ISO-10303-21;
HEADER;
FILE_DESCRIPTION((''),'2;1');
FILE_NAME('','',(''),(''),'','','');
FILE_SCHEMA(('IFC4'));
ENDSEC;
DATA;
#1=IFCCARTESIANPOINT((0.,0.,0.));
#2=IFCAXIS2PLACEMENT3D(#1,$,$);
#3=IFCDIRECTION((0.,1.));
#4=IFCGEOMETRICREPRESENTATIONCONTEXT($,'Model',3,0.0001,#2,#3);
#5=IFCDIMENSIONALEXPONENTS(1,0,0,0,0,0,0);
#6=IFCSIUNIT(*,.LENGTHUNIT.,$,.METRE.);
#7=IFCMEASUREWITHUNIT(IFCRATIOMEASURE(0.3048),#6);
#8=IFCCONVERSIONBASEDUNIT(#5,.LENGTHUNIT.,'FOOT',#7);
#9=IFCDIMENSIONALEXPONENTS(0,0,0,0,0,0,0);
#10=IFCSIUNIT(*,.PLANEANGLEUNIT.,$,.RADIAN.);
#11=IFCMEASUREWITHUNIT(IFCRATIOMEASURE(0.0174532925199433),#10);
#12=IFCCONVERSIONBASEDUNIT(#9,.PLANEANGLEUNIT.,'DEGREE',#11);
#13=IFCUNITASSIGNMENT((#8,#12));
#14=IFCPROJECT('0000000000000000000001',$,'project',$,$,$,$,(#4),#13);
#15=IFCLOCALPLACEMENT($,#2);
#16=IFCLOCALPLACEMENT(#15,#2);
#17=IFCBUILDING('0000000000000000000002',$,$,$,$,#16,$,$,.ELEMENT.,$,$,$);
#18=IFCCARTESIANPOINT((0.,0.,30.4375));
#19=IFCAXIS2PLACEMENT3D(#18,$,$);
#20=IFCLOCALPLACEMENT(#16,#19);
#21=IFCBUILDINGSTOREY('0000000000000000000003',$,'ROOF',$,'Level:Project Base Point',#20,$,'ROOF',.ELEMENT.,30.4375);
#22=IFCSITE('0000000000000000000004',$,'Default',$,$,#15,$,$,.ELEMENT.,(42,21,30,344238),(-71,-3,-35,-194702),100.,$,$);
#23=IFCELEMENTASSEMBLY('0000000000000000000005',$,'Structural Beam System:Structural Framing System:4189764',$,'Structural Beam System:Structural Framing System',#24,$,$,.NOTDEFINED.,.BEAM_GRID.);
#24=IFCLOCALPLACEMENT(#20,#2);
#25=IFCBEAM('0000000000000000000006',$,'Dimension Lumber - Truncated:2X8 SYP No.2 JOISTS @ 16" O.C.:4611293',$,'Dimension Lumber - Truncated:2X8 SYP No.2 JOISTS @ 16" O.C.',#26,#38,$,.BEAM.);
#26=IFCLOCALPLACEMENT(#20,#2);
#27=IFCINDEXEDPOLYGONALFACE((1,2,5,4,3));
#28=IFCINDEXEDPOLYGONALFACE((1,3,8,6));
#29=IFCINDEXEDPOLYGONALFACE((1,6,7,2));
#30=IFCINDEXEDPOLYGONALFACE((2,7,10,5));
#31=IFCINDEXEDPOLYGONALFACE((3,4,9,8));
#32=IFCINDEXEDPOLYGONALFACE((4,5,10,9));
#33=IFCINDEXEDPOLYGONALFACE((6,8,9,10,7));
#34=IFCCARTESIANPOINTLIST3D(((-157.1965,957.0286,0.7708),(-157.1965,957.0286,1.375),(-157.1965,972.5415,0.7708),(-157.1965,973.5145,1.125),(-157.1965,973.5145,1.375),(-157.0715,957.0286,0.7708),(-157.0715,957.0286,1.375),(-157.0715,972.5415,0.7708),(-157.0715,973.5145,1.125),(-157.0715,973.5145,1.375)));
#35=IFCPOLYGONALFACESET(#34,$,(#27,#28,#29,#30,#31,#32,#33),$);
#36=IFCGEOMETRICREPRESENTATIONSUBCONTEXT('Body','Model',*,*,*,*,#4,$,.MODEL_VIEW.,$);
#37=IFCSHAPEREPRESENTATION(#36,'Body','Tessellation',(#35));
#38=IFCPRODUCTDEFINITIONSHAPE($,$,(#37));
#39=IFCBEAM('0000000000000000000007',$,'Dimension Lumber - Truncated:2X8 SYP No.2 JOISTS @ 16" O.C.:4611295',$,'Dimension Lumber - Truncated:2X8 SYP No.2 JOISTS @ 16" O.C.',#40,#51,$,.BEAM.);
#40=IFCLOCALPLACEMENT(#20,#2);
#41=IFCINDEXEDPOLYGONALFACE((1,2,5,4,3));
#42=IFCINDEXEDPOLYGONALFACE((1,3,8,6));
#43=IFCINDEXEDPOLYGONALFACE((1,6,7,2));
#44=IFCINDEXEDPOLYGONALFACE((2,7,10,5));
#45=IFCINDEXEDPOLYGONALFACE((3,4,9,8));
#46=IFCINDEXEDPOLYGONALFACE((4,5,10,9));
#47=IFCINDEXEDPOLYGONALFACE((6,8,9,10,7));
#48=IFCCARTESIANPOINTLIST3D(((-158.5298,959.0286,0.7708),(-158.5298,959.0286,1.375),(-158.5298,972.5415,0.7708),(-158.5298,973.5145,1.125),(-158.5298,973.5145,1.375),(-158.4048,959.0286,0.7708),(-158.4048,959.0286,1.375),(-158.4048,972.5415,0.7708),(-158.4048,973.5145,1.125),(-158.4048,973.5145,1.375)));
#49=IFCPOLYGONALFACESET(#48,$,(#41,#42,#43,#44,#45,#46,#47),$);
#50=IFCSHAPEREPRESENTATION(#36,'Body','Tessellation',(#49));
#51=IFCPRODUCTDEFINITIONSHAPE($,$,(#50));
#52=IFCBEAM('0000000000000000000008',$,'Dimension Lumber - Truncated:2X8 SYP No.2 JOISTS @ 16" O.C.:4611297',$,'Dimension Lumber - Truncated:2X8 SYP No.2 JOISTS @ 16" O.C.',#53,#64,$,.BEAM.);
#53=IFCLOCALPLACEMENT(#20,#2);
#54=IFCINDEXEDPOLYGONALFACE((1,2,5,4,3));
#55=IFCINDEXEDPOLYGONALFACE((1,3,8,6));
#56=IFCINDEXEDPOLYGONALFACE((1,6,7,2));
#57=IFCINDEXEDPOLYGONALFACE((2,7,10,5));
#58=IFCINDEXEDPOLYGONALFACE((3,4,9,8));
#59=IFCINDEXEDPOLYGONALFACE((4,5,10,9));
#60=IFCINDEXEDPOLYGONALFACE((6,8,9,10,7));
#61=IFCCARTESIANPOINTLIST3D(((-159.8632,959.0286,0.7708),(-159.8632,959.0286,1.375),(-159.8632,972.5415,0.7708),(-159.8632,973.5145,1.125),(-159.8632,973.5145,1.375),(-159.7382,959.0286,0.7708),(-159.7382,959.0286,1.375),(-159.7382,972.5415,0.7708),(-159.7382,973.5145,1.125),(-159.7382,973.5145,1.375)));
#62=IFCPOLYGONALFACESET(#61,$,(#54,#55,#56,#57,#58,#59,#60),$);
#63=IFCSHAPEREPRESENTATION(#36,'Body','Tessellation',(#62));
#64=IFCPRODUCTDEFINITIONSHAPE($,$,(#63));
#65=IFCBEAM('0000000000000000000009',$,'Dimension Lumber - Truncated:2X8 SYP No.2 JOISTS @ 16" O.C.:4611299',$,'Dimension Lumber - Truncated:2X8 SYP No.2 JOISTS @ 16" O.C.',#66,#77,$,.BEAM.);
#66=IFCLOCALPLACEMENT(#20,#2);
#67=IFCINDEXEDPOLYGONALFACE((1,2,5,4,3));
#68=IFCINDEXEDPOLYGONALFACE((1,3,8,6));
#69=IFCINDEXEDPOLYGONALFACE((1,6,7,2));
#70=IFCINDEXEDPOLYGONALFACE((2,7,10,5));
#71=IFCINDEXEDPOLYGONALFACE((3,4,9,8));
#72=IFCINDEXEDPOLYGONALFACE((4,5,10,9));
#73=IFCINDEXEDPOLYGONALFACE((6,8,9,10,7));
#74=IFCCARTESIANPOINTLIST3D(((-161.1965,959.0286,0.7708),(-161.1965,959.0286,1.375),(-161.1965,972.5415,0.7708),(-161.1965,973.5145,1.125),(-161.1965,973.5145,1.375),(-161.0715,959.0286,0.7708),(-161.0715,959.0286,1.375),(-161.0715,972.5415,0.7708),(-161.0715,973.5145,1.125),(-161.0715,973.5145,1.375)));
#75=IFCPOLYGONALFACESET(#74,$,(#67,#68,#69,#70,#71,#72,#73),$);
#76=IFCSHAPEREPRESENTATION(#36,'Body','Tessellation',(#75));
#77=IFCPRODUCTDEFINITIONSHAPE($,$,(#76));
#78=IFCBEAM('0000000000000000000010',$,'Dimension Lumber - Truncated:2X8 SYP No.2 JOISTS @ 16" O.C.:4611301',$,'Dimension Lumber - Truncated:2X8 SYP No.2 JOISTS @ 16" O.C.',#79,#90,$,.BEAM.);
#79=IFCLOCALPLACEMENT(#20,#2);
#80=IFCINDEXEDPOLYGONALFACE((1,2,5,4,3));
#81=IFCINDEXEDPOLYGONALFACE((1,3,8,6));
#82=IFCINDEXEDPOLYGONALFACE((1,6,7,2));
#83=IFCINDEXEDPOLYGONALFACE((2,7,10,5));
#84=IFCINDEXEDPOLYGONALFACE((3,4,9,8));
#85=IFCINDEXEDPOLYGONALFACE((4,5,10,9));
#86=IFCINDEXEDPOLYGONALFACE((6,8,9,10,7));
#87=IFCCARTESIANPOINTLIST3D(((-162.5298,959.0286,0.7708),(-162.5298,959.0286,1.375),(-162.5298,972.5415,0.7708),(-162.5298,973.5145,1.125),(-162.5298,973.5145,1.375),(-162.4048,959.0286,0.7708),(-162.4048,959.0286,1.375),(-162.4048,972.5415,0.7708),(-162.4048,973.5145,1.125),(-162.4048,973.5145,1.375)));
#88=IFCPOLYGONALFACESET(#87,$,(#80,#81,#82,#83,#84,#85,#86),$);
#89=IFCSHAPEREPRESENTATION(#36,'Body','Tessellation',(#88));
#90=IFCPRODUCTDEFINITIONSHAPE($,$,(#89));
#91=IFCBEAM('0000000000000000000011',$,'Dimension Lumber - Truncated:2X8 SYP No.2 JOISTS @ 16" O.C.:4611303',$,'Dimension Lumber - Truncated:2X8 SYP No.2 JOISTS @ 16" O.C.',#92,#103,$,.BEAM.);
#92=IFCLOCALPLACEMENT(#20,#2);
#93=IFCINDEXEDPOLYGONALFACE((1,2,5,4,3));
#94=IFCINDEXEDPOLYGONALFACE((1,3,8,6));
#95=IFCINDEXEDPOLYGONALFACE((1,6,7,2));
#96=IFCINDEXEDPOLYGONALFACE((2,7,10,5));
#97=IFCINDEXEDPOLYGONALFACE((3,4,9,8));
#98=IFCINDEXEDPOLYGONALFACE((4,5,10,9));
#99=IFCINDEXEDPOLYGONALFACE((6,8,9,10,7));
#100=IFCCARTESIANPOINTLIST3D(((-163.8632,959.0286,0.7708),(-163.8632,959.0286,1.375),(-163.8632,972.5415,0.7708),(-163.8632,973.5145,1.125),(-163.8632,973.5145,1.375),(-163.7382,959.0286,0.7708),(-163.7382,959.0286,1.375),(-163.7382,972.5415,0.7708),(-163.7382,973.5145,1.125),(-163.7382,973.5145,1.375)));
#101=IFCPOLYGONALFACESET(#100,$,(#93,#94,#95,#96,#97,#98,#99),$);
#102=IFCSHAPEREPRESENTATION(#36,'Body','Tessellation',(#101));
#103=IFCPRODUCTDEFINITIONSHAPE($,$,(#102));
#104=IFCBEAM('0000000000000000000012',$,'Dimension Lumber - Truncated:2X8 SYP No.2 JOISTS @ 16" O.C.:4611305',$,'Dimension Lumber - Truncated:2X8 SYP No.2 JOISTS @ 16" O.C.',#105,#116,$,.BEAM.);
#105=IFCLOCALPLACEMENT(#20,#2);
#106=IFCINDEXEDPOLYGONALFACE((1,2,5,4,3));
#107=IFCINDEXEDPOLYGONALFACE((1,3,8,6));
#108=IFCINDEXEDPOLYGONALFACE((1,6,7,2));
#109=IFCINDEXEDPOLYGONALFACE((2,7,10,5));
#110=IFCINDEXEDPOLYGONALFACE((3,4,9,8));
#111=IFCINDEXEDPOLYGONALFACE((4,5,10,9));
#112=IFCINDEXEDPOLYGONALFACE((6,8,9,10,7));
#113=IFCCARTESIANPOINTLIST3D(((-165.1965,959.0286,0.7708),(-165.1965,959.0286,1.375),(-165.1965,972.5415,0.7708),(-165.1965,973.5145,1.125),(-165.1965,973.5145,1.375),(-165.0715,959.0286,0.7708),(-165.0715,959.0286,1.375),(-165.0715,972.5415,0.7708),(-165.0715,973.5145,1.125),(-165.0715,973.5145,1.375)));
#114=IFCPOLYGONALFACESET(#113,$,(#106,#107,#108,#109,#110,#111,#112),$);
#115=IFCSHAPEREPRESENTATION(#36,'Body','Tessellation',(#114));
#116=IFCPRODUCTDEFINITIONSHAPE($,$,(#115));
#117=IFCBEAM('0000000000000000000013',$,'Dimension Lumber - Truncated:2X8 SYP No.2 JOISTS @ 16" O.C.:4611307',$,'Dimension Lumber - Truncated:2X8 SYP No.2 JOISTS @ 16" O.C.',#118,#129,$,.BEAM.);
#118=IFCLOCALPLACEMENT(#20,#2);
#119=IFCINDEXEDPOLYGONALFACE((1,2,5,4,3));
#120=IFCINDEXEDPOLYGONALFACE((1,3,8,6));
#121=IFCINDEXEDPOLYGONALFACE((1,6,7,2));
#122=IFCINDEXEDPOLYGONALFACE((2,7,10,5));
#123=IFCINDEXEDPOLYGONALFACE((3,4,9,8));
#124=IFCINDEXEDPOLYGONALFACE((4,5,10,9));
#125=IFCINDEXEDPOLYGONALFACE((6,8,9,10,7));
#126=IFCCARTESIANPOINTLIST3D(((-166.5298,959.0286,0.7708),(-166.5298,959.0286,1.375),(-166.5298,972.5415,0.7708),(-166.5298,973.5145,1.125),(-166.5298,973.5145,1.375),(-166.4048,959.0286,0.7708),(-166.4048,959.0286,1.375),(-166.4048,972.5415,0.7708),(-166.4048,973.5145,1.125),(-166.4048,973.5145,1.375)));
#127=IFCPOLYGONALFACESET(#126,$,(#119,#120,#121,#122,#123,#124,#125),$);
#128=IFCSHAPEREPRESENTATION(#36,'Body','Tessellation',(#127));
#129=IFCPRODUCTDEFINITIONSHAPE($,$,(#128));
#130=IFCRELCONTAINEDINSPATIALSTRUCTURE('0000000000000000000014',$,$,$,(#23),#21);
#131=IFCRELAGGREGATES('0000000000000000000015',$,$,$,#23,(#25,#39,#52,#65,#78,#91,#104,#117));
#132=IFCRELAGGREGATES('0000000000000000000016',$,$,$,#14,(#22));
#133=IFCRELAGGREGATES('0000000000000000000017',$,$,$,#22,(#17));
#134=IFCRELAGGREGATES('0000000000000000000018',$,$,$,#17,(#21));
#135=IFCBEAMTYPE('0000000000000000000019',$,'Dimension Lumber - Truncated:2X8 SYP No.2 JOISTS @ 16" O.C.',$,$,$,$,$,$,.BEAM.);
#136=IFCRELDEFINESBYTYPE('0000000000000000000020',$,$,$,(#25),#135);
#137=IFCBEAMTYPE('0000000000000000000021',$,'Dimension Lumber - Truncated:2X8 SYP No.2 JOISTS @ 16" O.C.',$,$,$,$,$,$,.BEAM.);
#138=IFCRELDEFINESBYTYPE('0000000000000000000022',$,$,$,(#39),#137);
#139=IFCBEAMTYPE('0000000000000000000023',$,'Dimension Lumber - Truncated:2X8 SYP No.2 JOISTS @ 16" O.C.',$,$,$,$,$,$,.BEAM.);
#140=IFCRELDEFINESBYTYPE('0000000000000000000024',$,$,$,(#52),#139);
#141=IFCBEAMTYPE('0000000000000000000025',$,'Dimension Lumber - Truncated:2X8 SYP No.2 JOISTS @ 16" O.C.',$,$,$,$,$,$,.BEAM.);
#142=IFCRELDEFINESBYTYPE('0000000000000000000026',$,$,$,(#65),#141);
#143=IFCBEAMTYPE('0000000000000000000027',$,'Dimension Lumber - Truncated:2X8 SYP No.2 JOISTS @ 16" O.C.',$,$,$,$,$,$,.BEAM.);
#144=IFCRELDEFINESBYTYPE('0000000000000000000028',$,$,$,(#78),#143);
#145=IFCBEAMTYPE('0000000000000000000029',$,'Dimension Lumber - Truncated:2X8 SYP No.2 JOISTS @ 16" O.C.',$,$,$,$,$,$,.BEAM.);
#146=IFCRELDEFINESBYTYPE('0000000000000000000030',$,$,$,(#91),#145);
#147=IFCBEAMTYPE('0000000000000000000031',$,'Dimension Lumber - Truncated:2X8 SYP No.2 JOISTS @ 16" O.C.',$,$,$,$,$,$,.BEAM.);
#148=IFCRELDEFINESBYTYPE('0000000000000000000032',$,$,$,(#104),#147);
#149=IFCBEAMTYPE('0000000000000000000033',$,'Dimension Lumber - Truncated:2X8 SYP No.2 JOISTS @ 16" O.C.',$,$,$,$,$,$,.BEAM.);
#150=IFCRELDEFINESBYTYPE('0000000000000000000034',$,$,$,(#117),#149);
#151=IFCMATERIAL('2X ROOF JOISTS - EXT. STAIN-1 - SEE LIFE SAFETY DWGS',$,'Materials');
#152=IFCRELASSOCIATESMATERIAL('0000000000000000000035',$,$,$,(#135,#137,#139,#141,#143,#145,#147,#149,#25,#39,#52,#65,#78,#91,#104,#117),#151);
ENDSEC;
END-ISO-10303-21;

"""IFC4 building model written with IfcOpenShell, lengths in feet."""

from ifc_helpers import new_model, entity, si_unit, converted_unit, direction, frame, frame_2d, origin, place, context, subcontext, project, spatial, rectangle, extrude, clip, halfspace, source, transform, mapped, material, material_profile, profile_set, profile_usage, type_object, type_shapes, element, aggregate, save


model = new_model("IFC4")

# Units and contexts
model_context = context("Model", 3, precision=0.0001, world=origin(), true_north=direction((0.0, 1.0)))
body_context = subcontext(model_context, "Body", "Model", "MODEL_VIEW")
ifc_project = project(units=[converted_unit("LENGTHUNIT", "FOOT", entity("IfcRatioMeasure", 0.3048), si_unit("LENGTHUNIT", "METRE"), dimensions=[1, 0, 0, 0, 0, 0, 0]), converted_unit("PLANEANGLEUNIT", "DEGREE", entity("IfcRatioMeasure", 0.0174532925199433), si_unit("PLANEANGLEUNIT", "RADIAN"), dimensions=[0, 0, 0, 0, 0, 0, 0])], contexts=[model_context])

# Site, building, storey
site_placement = place(None, origin())
site = spatial("IfcSite", under=ifc_project, at=site_placement, Name="Default", CompositionType="ELEMENT", RefLatitude=(42, 21, 30, 344238), RefLongitude=(-71, -3, -35, -194702), RefElevation=100.0)
building_placement = place(site_placement, origin())
building = spatial("IfcBuilding", under=site, at=building_placement, CompositionType="ELEMENT")
storey_placement = place(building_placement, frame((0.0, 0.0, 30.4375)))
storey = spatial("IfcBuildingStorey", under=building, at=storey_placement, Name="ROOF", ObjectType="Level:Project Base Point", LongName="ROOF", CompositionType="ELEMENT", Elevation=30.4375)

# Element assembly, beams
assembly_1_placement = place(storey_placement, origin())
assembly_1 = element("IfcElementAssembly", 1, at=assembly_1_placement, inside=storey, Name="Structural Beam System:Structural Framing System:4189764", ObjectType="Structural Beam System:Structural Framing System", AssemblyPlace="NOTDEFINED", PredefinedType="BEAM_GRID")
ifc_material_1 = material(Name="2X ROOF JOISTS - EXT. STAIN-1 - SEE LIFE SAFETY DWGS", Category="Materials")
ifc_material_profile_1 = material_profile(ifc_material_1, rectangle(XDim=0.6042, YDim=0.125, at=frame_2d((0.0, 0.0), x_axis=(0.0, 1.0))), Name="2X8 SYP No.2 JOISTS @ 16\" O.C.")
ifc_profile_set_1 = profile_set([ifc_material_profile_1], Name="2X8 SYP No.2 JOISTS @ 16\" O.C.")
beam_type_1 = type_object("IfcBeamType", Name="Dimension Lumber - Truncated:2X8 SYP No.2 JOISTS @ 16\" O.C.", PredefinedType="BEAM", material=ifc_profile_set_1)
shared_shape_1 = source(origin(), body_context, "Body", "Clipping", [
    clip(extrude(rectangle(XDim=0.6042, YDim=0.125, at=frame_2d((0.0, 0.0), x_axis=(0.0, 1.0))), frame((-8.243, 0.0, 0.0), z_axis=(1.0, 0.0, 0.0), x_axis=(0.0, 1.0, 0.0)), (0.0, 0.0, 1.0), 16.4859), halfspace(frame((-7.2699, -0.0625, -0.3021), z_axis=(-0.34202, 0.0, -0.939693), x_axis=(0.0, 1.0, 0.0)), False)),
])
type_shapes(beam_type_1, [shared_shape_1])
ifc_profile_usage_1 = profile_usage(ifc_profile_set_1, cardinal=8)
beam_1_placement = place(assembly_1_placement, frame((-157.134, 965.2716, 1.0729), z_axis=(0.0, 0.0, 1.0), x_axis=(0.0, -1.0, 0.0)))
beam_1 = element("IfcBeam", 2, at=beam_1_placement, type_object=beam_type_1, material=ifc_profile_usage_1, Name="Dimension Lumber - Truncated:2X8 SYP No.2 JOISTS @ 16\" O.C.:4611293", ObjectType="Dimension Lumber - Truncated:2X8 SYP No.2 JOISTS @ 16\" O.C.", PredefinedType="BEAM", context=body_context, shape_type="MappedRepresentation", body=[
    mapped(shared_shape_1, transform((0.0, 0.0, 0.0), scale=1.0)),
])
ifc_profile_usage_2 = profile_usage(ifc_profile_set_1, cardinal=8)
beam_type_2 = type_object("IfcBeamType", Name="Dimension Lumber - Truncated:2X8 SYP No.2 JOISTS @ 16\" O.C.", PredefinedType="BEAM", material=ifc_profile_set_1)
shared_shape_2 = source(origin(), body_context, "Body", "Clipping", [
    clip(extrude(rectangle(XDim=0.6042, YDim=0.125, at=frame_2d((0.0, 0.0), x_axis=(0.0, 1.0))), frame((-7.243, 0.0, 0.0), z_axis=(1.0, 0.0, 0.0), x_axis=(0.0, 1.0, 0.0)), (0.0, 0.0, 1.0), 14.4859), halfspace(frame((-6.2699, -0.0625, -0.3021), z_axis=(-0.34202, 0.0, -0.939693), x_axis=(0.0, 1.0, 0.0)), False)),
])
type_shapes(beam_type_2, [shared_shape_2])
beam_2_placement = place(assembly_1_placement, frame((-158.4673, 966.2716, 1.0729), z_axis=(0.0, 0.0, 1.0), x_axis=(0.0, -1.0, 0.0)))
beam_2 = element("IfcBeam", 3, at=beam_2_placement, type_object=beam_type_2, material=ifc_profile_usage_2, Name="Dimension Lumber - Truncated:2X8 SYP No.2 JOISTS @ 16\" O.C.:4611295", ObjectType="Dimension Lumber - Truncated:2X8 SYP No.2 JOISTS @ 16\" O.C.", PredefinedType="BEAM", context=body_context, shape_type="MappedRepresentation", body=[
    mapped(shared_shape_2, transform((0.0, 0.0, 0.0), scale=1.0)),
])
ifc_profile_usage_3 = profile_usage(ifc_profile_set_1, cardinal=8)
beam_type_3 = type_object("IfcBeamType", Name="Dimension Lumber - Truncated:2X8 SYP No.2 JOISTS @ 16\" O.C.", PredefinedType="BEAM", material=ifc_profile_set_1)
shared_shape_3 = source(origin(), body_context, "Body", "Clipping", [
    clip(extrude(rectangle(XDim=0.6042, YDim=0.125, at=frame_2d((0.0, 0.0), x_axis=(0.0, 1.0))), frame((-7.243, 0.0, 0.0), z_axis=(1.0, 0.0, 0.0), x_axis=(0.0, 1.0, 0.0)), (0.0, 0.0, 1.0), 14.4859), halfspace(frame((-6.2699, -0.0625, -0.3021), z_axis=(-0.34202, 0.0, -0.939693), x_axis=(0.0, 1.0, 0.0)), False)),
])
type_shapes(beam_type_3, [shared_shape_3])
beam_3_placement = place(assembly_1_placement, frame((-159.8007, 966.2716, 1.0729), z_axis=(0.0, 0.0, 1.0), x_axis=(0.0, -1.0, 0.0)))
beam_3 = element("IfcBeam", 4, at=beam_3_placement, type_object=beam_type_3, material=ifc_profile_usage_3, Name="Dimension Lumber - Truncated:2X8 SYP No.2 JOISTS @ 16\" O.C.:4611297", ObjectType="Dimension Lumber - Truncated:2X8 SYP No.2 JOISTS @ 16\" O.C.", PredefinedType="BEAM", context=body_context, shape_type="MappedRepresentation", body=[
    mapped(shared_shape_3, transform((0.0, 0.0, 0.0), scale=1.0)),
])
ifc_profile_usage_4 = profile_usage(ifc_profile_set_1, cardinal=8)
beam_type_4 = type_object("IfcBeamType", Name="Dimension Lumber - Truncated:2X8 SYP No.2 JOISTS @ 16\" O.C.", PredefinedType="BEAM", material=ifc_profile_set_1)
shared_shape_4 = source(origin(), body_context, "Body", "Clipping", [
    clip(extrude(rectangle(XDim=0.6042, YDim=0.125, at=frame_2d((0.0, 0.0), x_axis=(0.0, 1.0))), frame((-7.243, 0.0, 0.0), z_axis=(1.0, 0.0, 0.0), x_axis=(0.0, 1.0, 0.0)), (0.0, 0.0, 1.0), 14.4859), halfspace(frame((-6.2699, -0.0625, -0.3021), z_axis=(-0.34202, 0.0, -0.939693), x_axis=(0.0, 1.0, 0.0)), False)),
])
type_shapes(beam_type_4, [shared_shape_4])
beam_4_placement = place(assembly_1_placement, frame((-161.134, 966.2716, 1.0729), z_axis=(0.0, 0.0, 1.0), x_axis=(0.0, -1.0, 0.0)))
beam_4 = element("IfcBeam", 5, at=beam_4_placement, type_object=beam_type_4, material=ifc_profile_usage_4, Name="Dimension Lumber - Truncated:2X8 SYP No.2 JOISTS @ 16\" O.C.:4611299", ObjectType="Dimension Lumber - Truncated:2X8 SYP No.2 JOISTS @ 16\" O.C.", PredefinedType="BEAM", context=body_context, shape_type="MappedRepresentation", body=[
    mapped(shared_shape_4, transform((0.0, 0.0, 0.0), scale=1.0)),
])
ifc_profile_usage_5 = profile_usage(ifc_profile_set_1, cardinal=8)
beam_type_5 = type_object("IfcBeamType", Name="Dimension Lumber - Truncated:2X8 SYP No.2 JOISTS @ 16\" O.C.", PredefinedType="BEAM", material=ifc_profile_set_1)
shared_shape_5 = source(origin(), body_context, "Body", "Clipping", [
    clip(extrude(rectangle(XDim=0.6042, YDim=0.125, at=frame_2d((0.0, 0.0), x_axis=(0.0, 1.0))), frame((-7.243, 0.0, 0.0), z_axis=(1.0, 0.0, 0.0), x_axis=(0.0, 1.0, 0.0)), (0.0, 0.0, 1.0), 14.4859), halfspace(frame((-6.2699, -0.0625, -0.3021), z_axis=(-0.34202, 0.0, -0.939693), x_axis=(0.0, 1.0, 0.0)), False)),
])
type_shapes(beam_type_5, [shared_shape_5])
beam_5_placement = place(assembly_1_placement, frame((-162.4673, 966.2716, 1.0729), z_axis=(0.0, 0.0, 1.0), x_axis=(0.0, -1.0, 0.0)))
beam_5 = element("IfcBeam", 6, at=beam_5_placement, type_object=beam_type_5, material=ifc_profile_usage_5, Name="Dimension Lumber - Truncated:2X8 SYP No.2 JOISTS @ 16\" O.C.:4611301", ObjectType="Dimension Lumber - Truncated:2X8 SYP No.2 JOISTS @ 16\" O.C.", PredefinedType="BEAM", context=body_context, shape_type="MappedRepresentation", body=[
    mapped(shared_shape_5, transform((0.0, 0.0, 0.0), scale=1.0)),
])
ifc_profile_usage_6 = profile_usage(ifc_profile_set_1, cardinal=8)
beam_type_6 = type_object("IfcBeamType", Name="Dimension Lumber - Truncated:2X8 SYP No.2 JOISTS @ 16\" O.C.", PredefinedType="BEAM", material=ifc_profile_set_1)
shared_shape_6 = source(origin(), body_context, "Body", "Clipping", [
    clip(extrude(rectangle(XDim=0.6042, YDim=0.125, at=frame_2d((0.0, 0.0), x_axis=(0.0, 1.0))), frame((-7.243, 0.0, 0.0), z_axis=(1.0, 0.0, 0.0), x_axis=(0.0, 1.0, 0.0)), (0.0, 0.0, 1.0), 14.4859), halfspace(frame((-6.2699, -0.0625, -0.3021), z_axis=(-0.34202, 0.0, -0.939693), x_axis=(0.0, 1.0, 0.0)), False)),
])
type_shapes(beam_type_6, [shared_shape_6])
beam_6_placement = place(assembly_1_placement, frame((-163.8007, 966.2716, 1.0729), z_axis=(0.0, 0.0, 1.0), x_axis=(0.0, -1.0, 0.0)))
beam_6 = element("IfcBeam", 7, at=beam_6_placement, type_object=beam_type_6, material=ifc_profile_usage_6, Name="Dimension Lumber - Truncated:2X8 SYP No.2 JOISTS @ 16\" O.C.:4611303", ObjectType="Dimension Lumber - Truncated:2X8 SYP No.2 JOISTS @ 16\" O.C.", PredefinedType="BEAM", context=body_context, shape_type="MappedRepresentation", body=[
    mapped(shared_shape_6, transform((0.0, 0.0, 0.0), scale=1.0)),
])
ifc_profile_usage_7 = profile_usage(ifc_profile_set_1, cardinal=8)
beam_type_7 = type_object("IfcBeamType", Name="Dimension Lumber - Truncated:2X8 SYP No.2 JOISTS @ 16\" O.C.", PredefinedType="BEAM", material=ifc_profile_set_1)
shared_shape_7 = source(origin(), body_context, "Body", "Clipping", [
    clip(extrude(rectangle(XDim=0.6042, YDim=0.125, at=frame_2d((0.0, 0.0), x_axis=(0.0, 1.0))), frame((-7.243, 0.0, 0.0), z_axis=(1.0, 0.0, 0.0), x_axis=(0.0, 1.0, 0.0)), (0.0, 0.0, 1.0), 14.4859), halfspace(frame((-6.2699, -0.0625, -0.3021), z_axis=(-0.34202, 0.0, -0.939693), x_axis=(0.0, 1.0, 0.0)), False)),
])
type_shapes(beam_type_7, [shared_shape_7])
beam_7_placement = place(assembly_1_placement, frame((-165.134, 966.2716, 1.0729), z_axis=(0.0, 0.0, 1.0), x_axis=(0.0, -1.0, 0.0)))
beam_7 = element("IfcBeam", 8, at=beam_7_placement, type_object=beam_type_7, material=ifc_profile_usage_7, Name="Dimension Lumber - Truncated:2X8 SYP No.2 JOISTS @ 16\" O.C.:4611305", ObjectType="Dimension Lumber - Truncated:2X8 SYP No.2 JOISTS @ 16\" O.C.", PredefinedType="BEAM", context=body_context, shape_type="MappedRepresentation", body=[
    mapped(shared_shape_7, transform((0.0, 0.0, 0.0), scale=1.0)),
])
ifc_profile_usage_8 = profile_usage(ifc_profile_set_1, cardinal=8)
beam_type_8 = type_object("IfcBeamType", Name="Dimension Lumber - Truncated:2X8 SYP No.2 JOISTS @ 16\" O.C.", PredefinedType="BEAM", material=ifc_profile_set_1)
shared_shape_8 = source(origin(), body_context, "Body", "Clipping", [
    clip(extrude(rectangle(XDim=0.6042, YDim=0.125, at=frame_2d((0.0, 0.0), x_axis=(0.0, 1.0))), frame((-7.243, 0.0, 0.0), z_axis=(1.0, 0.0, 0.0), x_axis=(0.0, 1.0, 0.0)), (0.0, 0.0, 1.0), 14.4859), halfspace(frame((-6.2699, -0.0625, -0.3021), z_axis=(-0.34202, 0.0, -0.939693), x_axis=(0.0, 1.0, 0.0)), False)),
])
type_shapes(beam_type_8, [shared_shape_8])
beam_8_placement = place(assembly_1_placement, frame((-166.4673, 966.2716, 1.0729), z_axis=(0.0, 0.0, 1.0), x_axis=(0.0, -1.0, 0.0)))
beam_8 = element("IfcBeam", 9, at=beam_8_placement, type_object=beam_type_8, material=ifc_profile_usage_8, Name="Dimension Lumber - Truncated:2X8 SYP No.2 JOISTS @ 16\" O.C.:4611307", ObjectType="Dimension Lumber - Truncated:2X8 SYP No.2 JOISTS @ 16\" O.C.", PredefinedType="BEAM", context=body_context, shape_type="MappedRepresentation", body=[
    mapped(shared_shape_8, transform((0.0, 0.0, 0.0), scale=1.0)),
])
aggregate(assembly_1, [beam_1, beam_2, beam_3, beam_4, beam_5, beam_6, beam_7, beam_8])

save(model, "model.ifc")
